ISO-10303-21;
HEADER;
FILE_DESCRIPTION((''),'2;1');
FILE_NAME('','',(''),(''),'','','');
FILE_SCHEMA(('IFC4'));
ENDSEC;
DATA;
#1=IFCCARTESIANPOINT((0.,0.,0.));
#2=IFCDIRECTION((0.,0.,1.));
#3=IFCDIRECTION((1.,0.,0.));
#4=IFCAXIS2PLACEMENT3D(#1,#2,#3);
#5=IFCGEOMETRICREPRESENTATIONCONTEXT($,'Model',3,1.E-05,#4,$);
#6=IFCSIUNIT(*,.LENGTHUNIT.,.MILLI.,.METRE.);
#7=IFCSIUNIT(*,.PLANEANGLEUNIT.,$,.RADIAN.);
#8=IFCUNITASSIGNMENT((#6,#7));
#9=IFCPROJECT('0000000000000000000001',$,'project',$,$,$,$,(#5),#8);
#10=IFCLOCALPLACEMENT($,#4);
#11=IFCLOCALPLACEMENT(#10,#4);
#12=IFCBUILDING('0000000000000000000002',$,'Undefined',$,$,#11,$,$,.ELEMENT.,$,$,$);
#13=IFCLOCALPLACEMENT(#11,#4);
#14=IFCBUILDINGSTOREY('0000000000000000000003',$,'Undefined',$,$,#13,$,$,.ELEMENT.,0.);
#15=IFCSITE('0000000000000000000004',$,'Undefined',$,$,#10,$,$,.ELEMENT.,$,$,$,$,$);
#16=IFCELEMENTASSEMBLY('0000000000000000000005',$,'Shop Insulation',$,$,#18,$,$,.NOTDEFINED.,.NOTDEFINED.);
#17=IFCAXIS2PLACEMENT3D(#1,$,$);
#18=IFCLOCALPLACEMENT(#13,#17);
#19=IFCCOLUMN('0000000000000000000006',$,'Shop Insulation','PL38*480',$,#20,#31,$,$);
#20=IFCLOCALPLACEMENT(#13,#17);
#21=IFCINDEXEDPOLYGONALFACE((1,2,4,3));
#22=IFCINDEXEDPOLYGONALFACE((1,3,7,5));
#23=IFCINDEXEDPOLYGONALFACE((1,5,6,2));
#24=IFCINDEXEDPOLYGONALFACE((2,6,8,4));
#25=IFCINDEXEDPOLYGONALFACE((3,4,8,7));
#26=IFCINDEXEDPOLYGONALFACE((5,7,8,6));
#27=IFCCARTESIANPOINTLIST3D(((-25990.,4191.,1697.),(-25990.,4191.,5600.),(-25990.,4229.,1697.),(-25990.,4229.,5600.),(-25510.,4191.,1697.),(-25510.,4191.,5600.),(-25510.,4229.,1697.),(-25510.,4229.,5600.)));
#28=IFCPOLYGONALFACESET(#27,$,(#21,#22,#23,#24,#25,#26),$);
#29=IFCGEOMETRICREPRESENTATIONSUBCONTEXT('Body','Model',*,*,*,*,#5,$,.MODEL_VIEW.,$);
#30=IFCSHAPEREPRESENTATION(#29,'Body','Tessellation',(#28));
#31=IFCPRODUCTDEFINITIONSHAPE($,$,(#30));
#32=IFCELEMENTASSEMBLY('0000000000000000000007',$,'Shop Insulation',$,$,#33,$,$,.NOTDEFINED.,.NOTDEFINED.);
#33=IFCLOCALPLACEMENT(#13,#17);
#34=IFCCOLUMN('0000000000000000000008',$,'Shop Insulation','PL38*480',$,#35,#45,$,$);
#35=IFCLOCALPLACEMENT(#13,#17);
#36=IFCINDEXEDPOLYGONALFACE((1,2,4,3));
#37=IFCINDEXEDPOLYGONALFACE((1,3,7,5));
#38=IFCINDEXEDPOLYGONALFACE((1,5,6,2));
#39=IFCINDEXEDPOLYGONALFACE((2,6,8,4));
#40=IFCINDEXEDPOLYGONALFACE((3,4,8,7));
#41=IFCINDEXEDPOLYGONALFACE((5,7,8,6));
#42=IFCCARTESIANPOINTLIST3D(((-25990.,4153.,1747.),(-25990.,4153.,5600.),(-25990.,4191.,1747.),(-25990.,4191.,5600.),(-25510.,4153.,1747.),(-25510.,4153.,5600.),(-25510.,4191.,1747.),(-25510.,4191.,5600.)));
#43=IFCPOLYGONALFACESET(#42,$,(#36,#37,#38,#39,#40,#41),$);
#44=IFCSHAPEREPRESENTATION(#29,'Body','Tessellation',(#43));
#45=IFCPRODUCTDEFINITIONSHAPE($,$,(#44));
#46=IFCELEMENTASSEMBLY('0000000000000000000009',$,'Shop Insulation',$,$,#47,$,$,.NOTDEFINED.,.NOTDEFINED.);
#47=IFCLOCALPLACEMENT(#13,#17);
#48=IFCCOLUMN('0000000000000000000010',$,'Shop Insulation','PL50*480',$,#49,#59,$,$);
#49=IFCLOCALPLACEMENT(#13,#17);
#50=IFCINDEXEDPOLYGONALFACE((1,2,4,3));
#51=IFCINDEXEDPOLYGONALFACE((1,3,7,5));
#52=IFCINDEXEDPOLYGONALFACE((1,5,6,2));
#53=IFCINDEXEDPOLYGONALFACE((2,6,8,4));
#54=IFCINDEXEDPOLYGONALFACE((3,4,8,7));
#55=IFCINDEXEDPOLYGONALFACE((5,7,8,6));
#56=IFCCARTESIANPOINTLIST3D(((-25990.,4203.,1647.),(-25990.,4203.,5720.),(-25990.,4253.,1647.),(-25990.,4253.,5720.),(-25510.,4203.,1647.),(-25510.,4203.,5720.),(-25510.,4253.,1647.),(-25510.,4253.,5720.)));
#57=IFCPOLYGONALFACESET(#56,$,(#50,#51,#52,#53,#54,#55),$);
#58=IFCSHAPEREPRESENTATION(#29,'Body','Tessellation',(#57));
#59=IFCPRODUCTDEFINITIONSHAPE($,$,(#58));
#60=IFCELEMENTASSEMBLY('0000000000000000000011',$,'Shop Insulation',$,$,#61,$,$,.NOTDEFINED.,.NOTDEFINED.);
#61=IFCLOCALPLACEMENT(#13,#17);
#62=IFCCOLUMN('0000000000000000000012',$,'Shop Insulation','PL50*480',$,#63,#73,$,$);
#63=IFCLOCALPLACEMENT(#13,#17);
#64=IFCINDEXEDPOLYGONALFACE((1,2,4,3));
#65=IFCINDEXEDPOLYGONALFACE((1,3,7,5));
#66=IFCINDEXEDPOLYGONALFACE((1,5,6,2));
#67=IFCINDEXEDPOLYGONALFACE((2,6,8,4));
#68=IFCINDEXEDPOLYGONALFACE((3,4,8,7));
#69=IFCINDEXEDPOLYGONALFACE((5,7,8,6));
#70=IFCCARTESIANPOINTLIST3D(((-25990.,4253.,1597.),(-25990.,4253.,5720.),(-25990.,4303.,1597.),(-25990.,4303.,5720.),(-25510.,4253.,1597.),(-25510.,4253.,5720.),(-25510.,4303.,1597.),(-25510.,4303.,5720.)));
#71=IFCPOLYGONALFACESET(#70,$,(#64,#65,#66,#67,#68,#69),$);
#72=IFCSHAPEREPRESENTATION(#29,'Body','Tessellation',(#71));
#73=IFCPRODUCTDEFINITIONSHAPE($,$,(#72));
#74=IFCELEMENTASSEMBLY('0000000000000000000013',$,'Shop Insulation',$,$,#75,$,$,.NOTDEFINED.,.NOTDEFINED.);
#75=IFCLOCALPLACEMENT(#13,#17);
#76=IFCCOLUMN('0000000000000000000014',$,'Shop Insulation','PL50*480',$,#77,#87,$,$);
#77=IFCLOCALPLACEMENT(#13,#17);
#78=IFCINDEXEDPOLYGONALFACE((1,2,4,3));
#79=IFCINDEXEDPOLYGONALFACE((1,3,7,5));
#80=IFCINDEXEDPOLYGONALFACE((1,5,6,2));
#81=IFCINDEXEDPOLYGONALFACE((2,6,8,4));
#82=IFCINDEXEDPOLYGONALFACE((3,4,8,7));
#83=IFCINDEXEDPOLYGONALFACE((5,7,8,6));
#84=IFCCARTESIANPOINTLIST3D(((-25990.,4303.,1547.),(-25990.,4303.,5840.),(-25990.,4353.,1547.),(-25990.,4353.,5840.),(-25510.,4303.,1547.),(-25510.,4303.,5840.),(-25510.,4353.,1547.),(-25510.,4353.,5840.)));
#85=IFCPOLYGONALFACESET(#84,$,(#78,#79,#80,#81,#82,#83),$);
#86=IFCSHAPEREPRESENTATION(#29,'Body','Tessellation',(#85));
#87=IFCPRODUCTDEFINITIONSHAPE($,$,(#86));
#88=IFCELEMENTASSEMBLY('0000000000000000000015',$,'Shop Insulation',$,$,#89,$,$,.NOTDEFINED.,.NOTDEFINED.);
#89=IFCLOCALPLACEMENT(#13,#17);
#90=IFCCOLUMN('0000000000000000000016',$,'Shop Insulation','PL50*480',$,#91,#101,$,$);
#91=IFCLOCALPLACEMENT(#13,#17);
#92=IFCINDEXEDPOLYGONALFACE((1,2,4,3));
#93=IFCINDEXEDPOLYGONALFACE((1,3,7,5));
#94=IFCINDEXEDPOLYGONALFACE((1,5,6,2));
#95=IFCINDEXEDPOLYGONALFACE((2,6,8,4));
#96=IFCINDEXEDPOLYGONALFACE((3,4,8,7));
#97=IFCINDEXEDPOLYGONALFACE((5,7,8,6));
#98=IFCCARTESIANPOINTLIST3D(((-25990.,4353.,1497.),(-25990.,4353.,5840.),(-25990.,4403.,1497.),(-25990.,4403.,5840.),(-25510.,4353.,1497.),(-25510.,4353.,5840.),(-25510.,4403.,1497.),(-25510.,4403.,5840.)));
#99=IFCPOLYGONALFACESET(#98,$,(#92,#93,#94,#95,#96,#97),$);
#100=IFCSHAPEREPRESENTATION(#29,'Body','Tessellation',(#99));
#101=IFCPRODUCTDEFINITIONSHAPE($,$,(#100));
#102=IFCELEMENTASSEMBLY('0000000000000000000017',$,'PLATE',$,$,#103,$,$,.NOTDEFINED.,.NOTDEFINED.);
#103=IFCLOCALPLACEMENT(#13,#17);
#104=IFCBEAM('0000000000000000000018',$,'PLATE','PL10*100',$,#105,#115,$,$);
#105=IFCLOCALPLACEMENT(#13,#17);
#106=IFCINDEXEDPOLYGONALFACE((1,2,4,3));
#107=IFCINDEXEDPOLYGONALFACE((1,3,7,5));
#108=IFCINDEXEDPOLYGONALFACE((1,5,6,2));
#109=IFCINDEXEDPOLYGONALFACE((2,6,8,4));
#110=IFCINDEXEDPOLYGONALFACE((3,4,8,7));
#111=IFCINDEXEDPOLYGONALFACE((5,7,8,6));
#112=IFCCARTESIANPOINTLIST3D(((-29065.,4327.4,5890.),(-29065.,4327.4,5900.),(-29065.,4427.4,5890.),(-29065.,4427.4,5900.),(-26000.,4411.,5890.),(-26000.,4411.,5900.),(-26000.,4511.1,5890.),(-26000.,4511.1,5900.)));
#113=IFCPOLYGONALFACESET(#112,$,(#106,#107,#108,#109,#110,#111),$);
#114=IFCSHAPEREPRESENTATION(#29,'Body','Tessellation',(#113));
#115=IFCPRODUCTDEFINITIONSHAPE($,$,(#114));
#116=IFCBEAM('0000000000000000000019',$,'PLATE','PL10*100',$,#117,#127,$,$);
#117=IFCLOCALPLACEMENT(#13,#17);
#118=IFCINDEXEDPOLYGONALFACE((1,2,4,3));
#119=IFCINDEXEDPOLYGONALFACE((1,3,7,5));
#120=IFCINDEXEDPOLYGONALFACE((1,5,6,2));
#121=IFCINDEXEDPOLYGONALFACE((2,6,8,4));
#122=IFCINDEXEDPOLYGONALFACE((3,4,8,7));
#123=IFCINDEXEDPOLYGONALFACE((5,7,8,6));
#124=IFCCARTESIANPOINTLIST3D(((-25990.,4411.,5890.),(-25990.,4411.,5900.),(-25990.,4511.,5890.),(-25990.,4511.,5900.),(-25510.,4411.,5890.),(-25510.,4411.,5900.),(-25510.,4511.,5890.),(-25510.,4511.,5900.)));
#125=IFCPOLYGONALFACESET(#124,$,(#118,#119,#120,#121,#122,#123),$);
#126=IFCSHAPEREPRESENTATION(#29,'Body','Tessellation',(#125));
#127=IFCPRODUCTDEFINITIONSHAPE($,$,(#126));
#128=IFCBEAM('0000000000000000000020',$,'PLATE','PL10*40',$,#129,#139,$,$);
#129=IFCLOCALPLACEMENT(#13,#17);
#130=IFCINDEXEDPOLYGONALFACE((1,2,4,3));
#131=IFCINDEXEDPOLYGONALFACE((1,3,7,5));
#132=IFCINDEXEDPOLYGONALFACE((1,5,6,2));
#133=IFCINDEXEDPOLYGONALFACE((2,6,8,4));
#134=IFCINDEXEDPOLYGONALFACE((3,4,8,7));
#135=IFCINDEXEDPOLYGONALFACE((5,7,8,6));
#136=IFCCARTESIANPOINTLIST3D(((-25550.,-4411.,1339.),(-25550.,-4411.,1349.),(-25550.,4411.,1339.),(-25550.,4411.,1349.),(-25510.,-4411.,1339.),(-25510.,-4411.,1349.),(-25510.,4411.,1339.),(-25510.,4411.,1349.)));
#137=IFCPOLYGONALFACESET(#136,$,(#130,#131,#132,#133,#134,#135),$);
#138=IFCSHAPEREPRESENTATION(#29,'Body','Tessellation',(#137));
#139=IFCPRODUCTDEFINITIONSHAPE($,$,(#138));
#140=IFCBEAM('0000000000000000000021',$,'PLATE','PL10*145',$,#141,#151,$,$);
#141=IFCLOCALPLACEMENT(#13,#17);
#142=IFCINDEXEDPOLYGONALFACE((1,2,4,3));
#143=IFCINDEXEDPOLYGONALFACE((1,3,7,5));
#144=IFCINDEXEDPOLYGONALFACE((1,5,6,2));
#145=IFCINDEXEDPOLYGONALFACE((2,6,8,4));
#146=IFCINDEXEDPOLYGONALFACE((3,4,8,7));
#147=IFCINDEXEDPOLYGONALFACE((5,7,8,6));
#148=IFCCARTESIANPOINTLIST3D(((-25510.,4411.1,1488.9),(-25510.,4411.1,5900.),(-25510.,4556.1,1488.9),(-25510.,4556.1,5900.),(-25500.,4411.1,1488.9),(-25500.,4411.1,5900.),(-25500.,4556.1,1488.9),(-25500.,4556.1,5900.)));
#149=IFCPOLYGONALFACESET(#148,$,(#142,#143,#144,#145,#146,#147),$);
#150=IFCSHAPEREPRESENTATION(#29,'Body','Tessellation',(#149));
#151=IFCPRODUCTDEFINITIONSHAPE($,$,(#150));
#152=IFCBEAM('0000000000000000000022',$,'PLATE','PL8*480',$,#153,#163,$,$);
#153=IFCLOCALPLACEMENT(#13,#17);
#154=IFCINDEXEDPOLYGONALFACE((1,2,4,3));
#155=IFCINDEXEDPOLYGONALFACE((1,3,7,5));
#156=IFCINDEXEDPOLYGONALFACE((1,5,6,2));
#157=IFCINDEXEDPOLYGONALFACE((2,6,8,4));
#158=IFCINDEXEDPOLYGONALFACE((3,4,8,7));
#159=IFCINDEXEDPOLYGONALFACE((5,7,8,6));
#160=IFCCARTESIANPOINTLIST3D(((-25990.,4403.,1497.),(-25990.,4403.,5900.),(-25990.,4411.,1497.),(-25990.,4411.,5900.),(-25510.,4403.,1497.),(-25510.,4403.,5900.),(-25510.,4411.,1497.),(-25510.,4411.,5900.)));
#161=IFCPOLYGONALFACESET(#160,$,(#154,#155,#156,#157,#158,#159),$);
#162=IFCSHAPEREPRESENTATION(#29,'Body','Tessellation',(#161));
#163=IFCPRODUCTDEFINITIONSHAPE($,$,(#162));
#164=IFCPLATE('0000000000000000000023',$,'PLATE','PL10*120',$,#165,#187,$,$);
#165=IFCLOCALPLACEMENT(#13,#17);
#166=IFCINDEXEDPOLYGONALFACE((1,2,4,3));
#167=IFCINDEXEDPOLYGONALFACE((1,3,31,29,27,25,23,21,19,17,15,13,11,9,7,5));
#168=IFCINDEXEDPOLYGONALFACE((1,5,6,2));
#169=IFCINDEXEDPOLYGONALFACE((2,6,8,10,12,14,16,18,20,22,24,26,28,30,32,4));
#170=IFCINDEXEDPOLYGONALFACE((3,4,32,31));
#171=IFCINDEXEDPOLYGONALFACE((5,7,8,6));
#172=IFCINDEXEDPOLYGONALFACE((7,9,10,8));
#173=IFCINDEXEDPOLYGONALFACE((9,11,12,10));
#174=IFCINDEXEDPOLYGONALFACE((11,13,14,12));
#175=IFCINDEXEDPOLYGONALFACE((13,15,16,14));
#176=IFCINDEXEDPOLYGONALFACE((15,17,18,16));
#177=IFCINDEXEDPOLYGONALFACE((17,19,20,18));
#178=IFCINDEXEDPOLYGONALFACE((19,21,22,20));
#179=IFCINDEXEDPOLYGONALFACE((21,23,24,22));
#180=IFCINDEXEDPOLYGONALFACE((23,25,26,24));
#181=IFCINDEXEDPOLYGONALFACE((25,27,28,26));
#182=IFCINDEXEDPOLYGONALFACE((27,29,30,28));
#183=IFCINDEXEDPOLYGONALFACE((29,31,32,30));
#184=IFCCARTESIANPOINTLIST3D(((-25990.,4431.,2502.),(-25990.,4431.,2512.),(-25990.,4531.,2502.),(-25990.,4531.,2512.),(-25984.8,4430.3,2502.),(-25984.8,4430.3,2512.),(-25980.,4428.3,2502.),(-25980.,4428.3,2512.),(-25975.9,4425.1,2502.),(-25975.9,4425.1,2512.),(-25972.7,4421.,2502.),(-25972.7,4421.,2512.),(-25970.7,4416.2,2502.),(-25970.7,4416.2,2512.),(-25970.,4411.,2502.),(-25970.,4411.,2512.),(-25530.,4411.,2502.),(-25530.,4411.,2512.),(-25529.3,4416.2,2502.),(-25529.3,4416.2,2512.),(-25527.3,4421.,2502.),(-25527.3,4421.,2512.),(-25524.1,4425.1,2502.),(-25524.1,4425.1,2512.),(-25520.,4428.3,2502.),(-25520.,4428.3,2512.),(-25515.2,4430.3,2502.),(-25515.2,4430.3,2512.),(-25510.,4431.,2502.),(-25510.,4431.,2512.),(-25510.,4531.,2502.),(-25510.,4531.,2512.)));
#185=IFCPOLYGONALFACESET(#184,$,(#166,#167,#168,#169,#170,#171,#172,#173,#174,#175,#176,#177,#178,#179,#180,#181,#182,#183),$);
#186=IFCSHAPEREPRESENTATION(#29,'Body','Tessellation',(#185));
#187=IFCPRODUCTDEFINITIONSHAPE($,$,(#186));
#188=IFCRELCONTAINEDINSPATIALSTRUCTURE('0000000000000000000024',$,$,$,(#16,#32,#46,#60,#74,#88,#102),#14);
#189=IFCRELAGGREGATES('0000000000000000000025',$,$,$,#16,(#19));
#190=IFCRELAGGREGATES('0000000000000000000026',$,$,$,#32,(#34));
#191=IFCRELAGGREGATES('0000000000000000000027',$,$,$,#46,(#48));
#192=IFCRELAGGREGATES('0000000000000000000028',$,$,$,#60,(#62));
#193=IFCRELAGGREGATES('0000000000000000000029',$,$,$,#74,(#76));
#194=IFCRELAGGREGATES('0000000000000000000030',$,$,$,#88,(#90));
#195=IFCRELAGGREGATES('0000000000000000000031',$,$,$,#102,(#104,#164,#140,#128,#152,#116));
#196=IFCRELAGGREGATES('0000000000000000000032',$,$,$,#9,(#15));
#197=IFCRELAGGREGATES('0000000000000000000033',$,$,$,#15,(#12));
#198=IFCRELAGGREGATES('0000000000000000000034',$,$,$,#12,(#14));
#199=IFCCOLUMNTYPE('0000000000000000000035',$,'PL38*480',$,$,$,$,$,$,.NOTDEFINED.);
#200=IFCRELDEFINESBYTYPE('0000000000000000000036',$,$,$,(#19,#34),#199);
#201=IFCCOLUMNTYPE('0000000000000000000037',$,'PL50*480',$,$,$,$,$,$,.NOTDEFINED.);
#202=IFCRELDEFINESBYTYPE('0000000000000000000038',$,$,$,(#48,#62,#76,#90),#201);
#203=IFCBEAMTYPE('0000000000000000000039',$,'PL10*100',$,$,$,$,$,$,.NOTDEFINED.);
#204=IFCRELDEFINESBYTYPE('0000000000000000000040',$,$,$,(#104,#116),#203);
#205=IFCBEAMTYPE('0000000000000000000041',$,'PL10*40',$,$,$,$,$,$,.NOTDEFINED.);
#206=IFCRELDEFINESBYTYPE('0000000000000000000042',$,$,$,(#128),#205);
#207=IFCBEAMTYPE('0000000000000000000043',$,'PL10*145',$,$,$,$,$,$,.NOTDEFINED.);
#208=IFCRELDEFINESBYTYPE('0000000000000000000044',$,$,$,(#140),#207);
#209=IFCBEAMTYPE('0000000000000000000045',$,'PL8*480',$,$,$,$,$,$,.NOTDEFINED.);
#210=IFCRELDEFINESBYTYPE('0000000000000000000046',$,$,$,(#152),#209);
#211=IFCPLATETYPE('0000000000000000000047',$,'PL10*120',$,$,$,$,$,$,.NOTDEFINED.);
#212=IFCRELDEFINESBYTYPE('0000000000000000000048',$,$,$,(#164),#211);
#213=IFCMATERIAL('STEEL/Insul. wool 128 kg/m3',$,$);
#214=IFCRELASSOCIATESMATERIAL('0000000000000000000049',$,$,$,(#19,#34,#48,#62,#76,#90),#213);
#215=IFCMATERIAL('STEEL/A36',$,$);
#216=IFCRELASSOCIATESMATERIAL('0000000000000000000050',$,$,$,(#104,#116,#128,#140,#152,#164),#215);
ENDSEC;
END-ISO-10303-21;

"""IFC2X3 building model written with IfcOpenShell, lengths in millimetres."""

from ifc_helpers import new_model, si_unit, frame, frame_2d, origin_with_axes, origin_2d_with_axis, place, context, subcontext, project, spatial, polyline, circle_curve, parameter, trimmed, segment, composite_curve, rectangle, outline, extrude, clip, halfspace, material, type_object, element, aggregate, save


model = new_model("IFC2X3")

# Units and contexts
model_context = context("Model", 3, precision=1e-05, world=origin_with_axes())
body_context = subcontext(model_context, "Body", "Model", "MODEL_VIEW")
ifc_project = project(units=[si_unit("LENGTHUNIT", "METRE", prefix="MILLI"), si_unit("PLANEANGLEUNIT", "RADIAN")], contexts=[model_context])

# Site, building, storey
site_placement = place(None, origin_with_axes())
site = spatial("IfcSite", under=ifc_project, at=site_placement, Name="Undefined", CompositionType="ELEMENT")
building_placement = place(site_placement, origin_with_axes())
building = spatial("IfcBuilding", under=site, at=building_placement, Name="Undefined", CompositionType="ELEMENT")
storey_placement = place(building_placement, origin_with_axes())
storey = spatial("IfcBuildingStorey", under=building, at=storey_placement, Name="Undefined", CompositionType="ELEMENT", Elevation=0.0)

# Element assemblies, columns
assembly_1_placement = place(storey_placement, origin_with_axes())
assembly_1 = element("IfcElementAssembly", 1, at=assembly_1_placement, inside=storey, Name="Shop Insulation", AssemblyPlace="NOTDEFINED", PredefinedType="NOTDEFINED")
ifc_material_1 = material(Name="STEEL/Insul. wool 128 kg/m3")
column_type_1 = type_object("IfcColumnType", Name="PL38*480", PredefinedType="NOTDEFINED")
column_1_placement = place(assembly_1_placement, frame((-25750.0, 4210.0, 1697.0), z_axis=(-0.00001, 0.0, 1.0), x_axis=(-1.0, 0.0, -0.00001)))
column_1 = element("IfcColumn", 2, at=column_1_placement, type_object=column_type_1, material=ifc_material_1, Name="Shop Insulation", Description="PL38*480", context=body_context, shape_type="SweptSolid", body=[
    extrude(rectangle(XDim=38.0, YDim=480.0, at=origin_2d_with_axis()), frame((0.0, 0.0, 3903.0), z_axis=(0.0, 0.0, -1.0), x_axis=(0.0, 1.0, 0.0)), (0.0, 0.0, 1.0), 3903.0),
])
aggregate(assembly_1, [column_1])
assembly_2_placement = place(storey_placement, origin_with_axes())
assembly_2 = element("IfcElementAssembly", 3, at=assembly_2_placement, inside=storey, Name="Shop Insulation", AssemblyPlace="NOTDEFINED", PredefinedType="NOTDEFINED")
column_2_placement = place(assembly_2_placement, frame((-25750.0, 4172.0, 1747.0), z_axis=(-0.00001, 0.0, 1.0), x_axis=(-1.0, 0.0, -0.00001)))
column_2 = element("IfcColumn", 4, at=column_2_placement, type_object=column_type_1, material=ifc_material_1, Name="Shop Insulation", Description="PL38*480", context=body_context, shape_type="SweptSolid", body=[
    extrude(rectangle(XDim=38.0, YDim=480.0, at=origin_2d_with_axis()), frame((0.0, 0.0, 3853.0), z_axis=(0.0, 0.0, -1.0), x_axis=(0.0, 1.0, 0.0)), (0.0, 0.0, 1.0), 3853.0),
])
aggregate(assembly_2, [column_2])
assembly_3_placement = place(storey_placement, origin_with_axes())
assembly_3 = element("IfcElementAssembly", 5, at=assembly_3_placement, inside=storey, Name="Shop Insulation", AssemblyPlace="NOTDEFINED", PredefinedType="NOTDEFINED")
column_type_2 = type_object("IfcColumnType", Name="PL50*480", PredefinedType="NOTDEFINED")
column_3_placement = place(assembly_3_placement, frame((-25750.0, 4228.0, 1647.0), z_axis=(-0.00001, 0.0, 1.0), x_axis=(-1.0, 0.0, -0.00001)))
column_3 = element("IfcColumn", 6, at=column_3_placement, type_object=column_type_2, material=ifc_material_1, Name="Shop Insulation", Description="PL50*480", context=body_context, shape_type="Clipping", body=[
    clip(extrude(rectangle(XDim=50.0, YDim=480.0, at=origin_2d_with_axis()), frame((0.0, 0.0, 4073.0), z_axis=(0.0, 0.0, -1.0), x_axis=(0.0, 1.0, 0.0)), (0.0, 0.0, 1.0), 4073.0), halfspace(frame((-240.0, -25.0, 4153.0), z_axis=(-0.00001, 0.0, 1.0), x_axis=(0.0, 1.0, 0.0)), False)),
])
aggregate(assembly_3, [column_3])
assembly_4_placement = place(storey_placement, origin_with_axes())
assembly_4 = element("IfcElementAssembly", 7, at=assembly_4_placement, inside=storey, Name="Shop Insulation", AssemblyPlace="NOTDEFINED", PredefinedType="NOTDEFINED")
column_4_placement = place(assembly_4_placement, frame((-25750.0, 4278.0, 1597.0), z_axis=(-0.00001, 0.0, 1.0), x_axis=(-1.0, 0.0, -0.00001)))
column_4 = element("IfcColumn", 8, at=column_4_placement, type_object=column_type_2, material=ifc_material_1, Name="Shop Insulation", Description="PL50*480", context=body_context, shape_type="Clipping", body=[
    clip(extrude(rectangle(XDim=50.0, YDim=480.0, at=origin_2d_with_axis()), frame((0.0, 0.0, 4123.0), z_axis=(0.0, 0.0, -1.0), x_axis=(0.0, 1.0, 0.0)), (0.0, 0.0, 1.0), 4123.0), halfspace(frame((-240.0, -25.0, 4228.0), z_axis=(-0.00001, 0.0, 1.0), x_axis=(0.0, 1.0, 0.0)), False)),
])
aggregate(assembly_4, [column_4])
assembly_5_placement = place(storey_placement, origin_with_axes())
assembly_5 = element("IfcElementAssembly", 9, at=assembly_5_placement, inside=storey, Name="Shop Insulation", AssemblyPlace="NOTDEFINED", PredefinedType="NOTDEFINED")
column_5_placement = place(assembly_5_placement, frame((-25750.0, 4328.0, 1547.0), z_axis=(-0.00001, 0.0, 1.0), x_axis=(-1.0, 0.0, -0.00001)))
column_5 = element("IfcColumn", 10, at=column_5_placement, type_object=column_type_2, material=ifc_material_1, Name="Shop Insulation", Description="PL50*480", context=body_context, shape_type="Clipping", body=[
    clip(extrude(rectangle(XDim=50.0, YDim=480.0, at=origin_2d_with_axis()), frame((0.0, 0.0, 4293.0), z_axis=(0.0, 0.0, -1.0), x_axis=(0.0, 1.0, 0.0)), (0.0, 0.0, 1.0), 4293.0), halfspace(frame((-240.0, -25.0, 4303.0), z_axis=(-0.00001, 0.0, 1.0), x_axis=(0.0, 1.0, 0.0)), False)),
])
aggregate(assembly_5, [column_5])
assembly_6_placement = place(storey_placement, origin_with_axes())
assembly_6 = element("IfcElementAssembly", 11, at=assembly_6_placement, inside=storey, Name="Shop Insulation", AssemblyPlace="NOTDEFINED", PredefinedType="NOTDEFINED")
column_6_placement = place(assembly_6_placement, frame((-25750.0, 4378.0, 1497.0), z_axis=(-0.00001, 0.0, 1.0), x_axis=(-1.0, 0.0, -0.00001)))
column_6 = element("IfcColumn", 12, at=column_6_placement, type_object=column_type_2, material=ifc_material_1, Name="Shop Insulation", Description="PL50*480", context=body_context, shape_type="SweptSolid", body=[
    extrude(rectangle(XDim=50.0, YDim=480.0, at=origin_2d_with_axis()), frame((0.0, 0.0, 4343.0), z_axis=(0.0, 0.0, -1.0), x_axis=(0.0, 1.0, 0.0)), (0.0, 0.0, 1.0), 4343.0),
])
aggregate(assembly_6, [column_6])

# Element assembly, beams, plate
assembly_7_placement = place(storey_placement, origin_with_axes())
assembly_7 = element("IfcElementAssembly", 13, at=assembly_7_placement, inside=storey, Name="PLATE", AssemblyPlace="NOTDEFINED", PredefinedType="NOTDEFINED")
ifc_material_2 = material(Name="STEEL/A36")
beam_type_1 = type_object("IfcBeamType", Name="PL10*100", PredefinedType="NOTDEFINED")
beam_1_placement = place(assembly_7_placement, frame((-25998.6, 4461.1, 5895.0), z_axis=(-0.027288, 0.999628, 0.0), x_axis=(-0.999628, -0.027287, 0.0)))
beam_1 = element("IfcBeam", 14, at=beam_1_placement, type_object=beam_type_1, material=ifc_material_2, Name="PLATE", Description="PL10*100", context=body_context, shape_type="Clipping", body=[
    clip(clip(extrude(rectangle(XDim=10.0, YDim=100.0, at=origin_2d_with_axis()), frame((3081.1, 0.0, 0.0), z_axis=(-1.0, 0.0, 0.0), x_axis=(0.0, -1.0, 0.0)), (0.0, 0.0, 1.0), 3081.1), halfspace(frame((2.7, 5.0, -50.0), z_axis=(-0.999628, 0.0, -0.027287), x_axis=(-0.027287, 0.0, 0.999628)), False)), halfspace(frame((3066.4, -5895.0, 40.0), z_axis=(0.999624, 0.0, 0.027424), x_axis=(0.0, 1.0, 0.0)), False)),
])
beam_2_placement = place(assembly_7_placement, frame((-25510.0, 4461.0, 5895.0), z_axis=(-0.000007, 1.0, 0.0), x_axis=(-1.0, -0.000007, 0.0)))
beam_2 = element("IfcBeam", 15, at=beam_2_placement, type_object=beam_type_1, material=ifc_material_2, Name="PLATE", Description="PL10*100", context=body_context, shape_type="SweptSolid", body=[
    extrude(rectangle(XDim=10.0, YDim=100.0, at=origin_2d_with_axis()), frame((480.0, 0.0, 0.0), z_axis=(-1.0, 0.0, 0.0), x_axis=(0.0, -1.0, 0.0)), (0.0, 0.0, 1.0), 480.0),
])
beam_type_2 = type_object("IfcBeamType", Name="PL10*40", PredefinedType="NOTDEFINED")
beam_3_placement = place(assembly_7_placement, frame((-25530.0, 4411.0, 1344.0), z_axis=(1.0, 0.0, 0.0), x_axis=(0.0, -1.0, 0.0)))
beam_3 = element("IfcBeam", 16, at=beam_3_placement, type_object=beam_type_2, material=ifc_material_2, Name="PLATE", Description="PL10*40", context=body_context, shape_type="SweptSolid", body=[
    extrude(rectangle(XDim=10.0, YDim=40.0, at=origin_2d_with_axis()), frame((8822.0, 0.0, 0.0), z_axis=(-1.0, 0.0, 0.0), x_axis=(0.0, -1.0, 0.0)), (0.0, 0.0, 1.0), 8822.0),
])
beam_type_3 = type_object("IfcBeamType", Name="PL10*145", PredefinedType="NOTDEFINED")
beam_4_placement = place(assembly_7_placement, frame((-25505.0, 4483.6, 5900.0), z_axis=(0.0, 1.0, 0.0), x_axis=(0.0, 0.0, -1.0)))
beam_4 = element("IfcBeam", 17, at=beam_4_placement, type_object=beam_type_3, material=ifc_material_2, Name="PLATE", Description="PL10*145", context=body_context, shape_type="SweptSolid", body=[
    extrude(rectangle(XDim=10.0, YDim=145.0, at=origin_2d_with_axis()), frame((4411.1, 0.0, 0.0), z_axis=(-1.0, 0.0, 0.0), x_axis=(0.0, -1.0, 0.0)), (0.0, 0.0, 1.0), 4411.1),
])
beam_type_4 = type_object("IfcBeamType", Name="PL8*480", PredefinedType="NOTDEFINED")
beam_5_placement = place(assembly_7_placement, frame((-25750.0, 4407.0, 1497.0), z_axis=(1.0, 0.0, 0.0), x_axis=(0.0, 0.000007, 1.0)))
beam_5 = element("IfcBeam", 18, at=beam_5_placement, type_object=beam_type_4, material=ifc_material_2, Name="PLATE", Description="PL8*480", context=body_context, shape_type="SweptSolid", body=[
    extrude(rectangle(XDim=8.0, YDim=480.0, at=origin_2d_with_axis()), frame((4403.0, 0.0, 0.0), z_axis=(-1.0, 0.0, 0.0), x_axis=(0.0, -1.0, 0.0)), (0.0, 0.0, 1.0), 4403.0),
])
plate_type_1 = type_object("IfcPlateType", Name="PL10*120", PredefinedType="NOTDEFINED")
plate_1_placement = place(assembly_7_placement, frame((-25510.0, 4531.0, 2507.0), z_axis=(0.0, 0.0, 1.0), x_axis=(-1.0, 0.0, 0.0)))
plate_1 = element("IfcPlate", 19, at=plate_1_placement, type_object=plate_type_1, material=ifc_material_2, Name="PLATE", Description="PL10*120", context=body_context, shape_type="SweptSolid", body=[
    extrude(outline(composite_curve([segment(polyline([(0.0, 0.0), (480.0, 0.0), (480.0, 100.0)]), True, "CONTINUOUS"), segment(trimmed(circle_curve(frame_2d((480.0, 120.0), x_axis=(-0.000015, -1.0)), 20.0), [parameter(0.0)], [parameter(4.712402)], False, "PARAMETER"), True, "CONTINUOUS"), segment(polyline([(460.0, 120.0), (20.0, 120.0)]), True, "CONTINUOUS"), segment(trimmed(circle_curve(frame_2d((0.0, 120.0), x_axis=(1.0, -0.000002)), 20.0), [parameter(0.0)], [parameter(4.712393)], False, "PARAMETER"), True, "CONTINUOUS"), segment(polyline([(0.0, 100.0), (0.0, 0.0)]), True, "CONTINUOUS")], self_intersect=True)), frame((0.0, 0.0, -5.0), z_axis=(0.0, 0.0, 1.0), x_axis=(1.0, 0.0, 0.0)), (0.0, 0.0, 1.0), 10.0),
])

aggregate(assembly_7, [beam_1, plate_1, beam_4, beam_3, beam_5, beam_2])

save(model, "model.ifc")
